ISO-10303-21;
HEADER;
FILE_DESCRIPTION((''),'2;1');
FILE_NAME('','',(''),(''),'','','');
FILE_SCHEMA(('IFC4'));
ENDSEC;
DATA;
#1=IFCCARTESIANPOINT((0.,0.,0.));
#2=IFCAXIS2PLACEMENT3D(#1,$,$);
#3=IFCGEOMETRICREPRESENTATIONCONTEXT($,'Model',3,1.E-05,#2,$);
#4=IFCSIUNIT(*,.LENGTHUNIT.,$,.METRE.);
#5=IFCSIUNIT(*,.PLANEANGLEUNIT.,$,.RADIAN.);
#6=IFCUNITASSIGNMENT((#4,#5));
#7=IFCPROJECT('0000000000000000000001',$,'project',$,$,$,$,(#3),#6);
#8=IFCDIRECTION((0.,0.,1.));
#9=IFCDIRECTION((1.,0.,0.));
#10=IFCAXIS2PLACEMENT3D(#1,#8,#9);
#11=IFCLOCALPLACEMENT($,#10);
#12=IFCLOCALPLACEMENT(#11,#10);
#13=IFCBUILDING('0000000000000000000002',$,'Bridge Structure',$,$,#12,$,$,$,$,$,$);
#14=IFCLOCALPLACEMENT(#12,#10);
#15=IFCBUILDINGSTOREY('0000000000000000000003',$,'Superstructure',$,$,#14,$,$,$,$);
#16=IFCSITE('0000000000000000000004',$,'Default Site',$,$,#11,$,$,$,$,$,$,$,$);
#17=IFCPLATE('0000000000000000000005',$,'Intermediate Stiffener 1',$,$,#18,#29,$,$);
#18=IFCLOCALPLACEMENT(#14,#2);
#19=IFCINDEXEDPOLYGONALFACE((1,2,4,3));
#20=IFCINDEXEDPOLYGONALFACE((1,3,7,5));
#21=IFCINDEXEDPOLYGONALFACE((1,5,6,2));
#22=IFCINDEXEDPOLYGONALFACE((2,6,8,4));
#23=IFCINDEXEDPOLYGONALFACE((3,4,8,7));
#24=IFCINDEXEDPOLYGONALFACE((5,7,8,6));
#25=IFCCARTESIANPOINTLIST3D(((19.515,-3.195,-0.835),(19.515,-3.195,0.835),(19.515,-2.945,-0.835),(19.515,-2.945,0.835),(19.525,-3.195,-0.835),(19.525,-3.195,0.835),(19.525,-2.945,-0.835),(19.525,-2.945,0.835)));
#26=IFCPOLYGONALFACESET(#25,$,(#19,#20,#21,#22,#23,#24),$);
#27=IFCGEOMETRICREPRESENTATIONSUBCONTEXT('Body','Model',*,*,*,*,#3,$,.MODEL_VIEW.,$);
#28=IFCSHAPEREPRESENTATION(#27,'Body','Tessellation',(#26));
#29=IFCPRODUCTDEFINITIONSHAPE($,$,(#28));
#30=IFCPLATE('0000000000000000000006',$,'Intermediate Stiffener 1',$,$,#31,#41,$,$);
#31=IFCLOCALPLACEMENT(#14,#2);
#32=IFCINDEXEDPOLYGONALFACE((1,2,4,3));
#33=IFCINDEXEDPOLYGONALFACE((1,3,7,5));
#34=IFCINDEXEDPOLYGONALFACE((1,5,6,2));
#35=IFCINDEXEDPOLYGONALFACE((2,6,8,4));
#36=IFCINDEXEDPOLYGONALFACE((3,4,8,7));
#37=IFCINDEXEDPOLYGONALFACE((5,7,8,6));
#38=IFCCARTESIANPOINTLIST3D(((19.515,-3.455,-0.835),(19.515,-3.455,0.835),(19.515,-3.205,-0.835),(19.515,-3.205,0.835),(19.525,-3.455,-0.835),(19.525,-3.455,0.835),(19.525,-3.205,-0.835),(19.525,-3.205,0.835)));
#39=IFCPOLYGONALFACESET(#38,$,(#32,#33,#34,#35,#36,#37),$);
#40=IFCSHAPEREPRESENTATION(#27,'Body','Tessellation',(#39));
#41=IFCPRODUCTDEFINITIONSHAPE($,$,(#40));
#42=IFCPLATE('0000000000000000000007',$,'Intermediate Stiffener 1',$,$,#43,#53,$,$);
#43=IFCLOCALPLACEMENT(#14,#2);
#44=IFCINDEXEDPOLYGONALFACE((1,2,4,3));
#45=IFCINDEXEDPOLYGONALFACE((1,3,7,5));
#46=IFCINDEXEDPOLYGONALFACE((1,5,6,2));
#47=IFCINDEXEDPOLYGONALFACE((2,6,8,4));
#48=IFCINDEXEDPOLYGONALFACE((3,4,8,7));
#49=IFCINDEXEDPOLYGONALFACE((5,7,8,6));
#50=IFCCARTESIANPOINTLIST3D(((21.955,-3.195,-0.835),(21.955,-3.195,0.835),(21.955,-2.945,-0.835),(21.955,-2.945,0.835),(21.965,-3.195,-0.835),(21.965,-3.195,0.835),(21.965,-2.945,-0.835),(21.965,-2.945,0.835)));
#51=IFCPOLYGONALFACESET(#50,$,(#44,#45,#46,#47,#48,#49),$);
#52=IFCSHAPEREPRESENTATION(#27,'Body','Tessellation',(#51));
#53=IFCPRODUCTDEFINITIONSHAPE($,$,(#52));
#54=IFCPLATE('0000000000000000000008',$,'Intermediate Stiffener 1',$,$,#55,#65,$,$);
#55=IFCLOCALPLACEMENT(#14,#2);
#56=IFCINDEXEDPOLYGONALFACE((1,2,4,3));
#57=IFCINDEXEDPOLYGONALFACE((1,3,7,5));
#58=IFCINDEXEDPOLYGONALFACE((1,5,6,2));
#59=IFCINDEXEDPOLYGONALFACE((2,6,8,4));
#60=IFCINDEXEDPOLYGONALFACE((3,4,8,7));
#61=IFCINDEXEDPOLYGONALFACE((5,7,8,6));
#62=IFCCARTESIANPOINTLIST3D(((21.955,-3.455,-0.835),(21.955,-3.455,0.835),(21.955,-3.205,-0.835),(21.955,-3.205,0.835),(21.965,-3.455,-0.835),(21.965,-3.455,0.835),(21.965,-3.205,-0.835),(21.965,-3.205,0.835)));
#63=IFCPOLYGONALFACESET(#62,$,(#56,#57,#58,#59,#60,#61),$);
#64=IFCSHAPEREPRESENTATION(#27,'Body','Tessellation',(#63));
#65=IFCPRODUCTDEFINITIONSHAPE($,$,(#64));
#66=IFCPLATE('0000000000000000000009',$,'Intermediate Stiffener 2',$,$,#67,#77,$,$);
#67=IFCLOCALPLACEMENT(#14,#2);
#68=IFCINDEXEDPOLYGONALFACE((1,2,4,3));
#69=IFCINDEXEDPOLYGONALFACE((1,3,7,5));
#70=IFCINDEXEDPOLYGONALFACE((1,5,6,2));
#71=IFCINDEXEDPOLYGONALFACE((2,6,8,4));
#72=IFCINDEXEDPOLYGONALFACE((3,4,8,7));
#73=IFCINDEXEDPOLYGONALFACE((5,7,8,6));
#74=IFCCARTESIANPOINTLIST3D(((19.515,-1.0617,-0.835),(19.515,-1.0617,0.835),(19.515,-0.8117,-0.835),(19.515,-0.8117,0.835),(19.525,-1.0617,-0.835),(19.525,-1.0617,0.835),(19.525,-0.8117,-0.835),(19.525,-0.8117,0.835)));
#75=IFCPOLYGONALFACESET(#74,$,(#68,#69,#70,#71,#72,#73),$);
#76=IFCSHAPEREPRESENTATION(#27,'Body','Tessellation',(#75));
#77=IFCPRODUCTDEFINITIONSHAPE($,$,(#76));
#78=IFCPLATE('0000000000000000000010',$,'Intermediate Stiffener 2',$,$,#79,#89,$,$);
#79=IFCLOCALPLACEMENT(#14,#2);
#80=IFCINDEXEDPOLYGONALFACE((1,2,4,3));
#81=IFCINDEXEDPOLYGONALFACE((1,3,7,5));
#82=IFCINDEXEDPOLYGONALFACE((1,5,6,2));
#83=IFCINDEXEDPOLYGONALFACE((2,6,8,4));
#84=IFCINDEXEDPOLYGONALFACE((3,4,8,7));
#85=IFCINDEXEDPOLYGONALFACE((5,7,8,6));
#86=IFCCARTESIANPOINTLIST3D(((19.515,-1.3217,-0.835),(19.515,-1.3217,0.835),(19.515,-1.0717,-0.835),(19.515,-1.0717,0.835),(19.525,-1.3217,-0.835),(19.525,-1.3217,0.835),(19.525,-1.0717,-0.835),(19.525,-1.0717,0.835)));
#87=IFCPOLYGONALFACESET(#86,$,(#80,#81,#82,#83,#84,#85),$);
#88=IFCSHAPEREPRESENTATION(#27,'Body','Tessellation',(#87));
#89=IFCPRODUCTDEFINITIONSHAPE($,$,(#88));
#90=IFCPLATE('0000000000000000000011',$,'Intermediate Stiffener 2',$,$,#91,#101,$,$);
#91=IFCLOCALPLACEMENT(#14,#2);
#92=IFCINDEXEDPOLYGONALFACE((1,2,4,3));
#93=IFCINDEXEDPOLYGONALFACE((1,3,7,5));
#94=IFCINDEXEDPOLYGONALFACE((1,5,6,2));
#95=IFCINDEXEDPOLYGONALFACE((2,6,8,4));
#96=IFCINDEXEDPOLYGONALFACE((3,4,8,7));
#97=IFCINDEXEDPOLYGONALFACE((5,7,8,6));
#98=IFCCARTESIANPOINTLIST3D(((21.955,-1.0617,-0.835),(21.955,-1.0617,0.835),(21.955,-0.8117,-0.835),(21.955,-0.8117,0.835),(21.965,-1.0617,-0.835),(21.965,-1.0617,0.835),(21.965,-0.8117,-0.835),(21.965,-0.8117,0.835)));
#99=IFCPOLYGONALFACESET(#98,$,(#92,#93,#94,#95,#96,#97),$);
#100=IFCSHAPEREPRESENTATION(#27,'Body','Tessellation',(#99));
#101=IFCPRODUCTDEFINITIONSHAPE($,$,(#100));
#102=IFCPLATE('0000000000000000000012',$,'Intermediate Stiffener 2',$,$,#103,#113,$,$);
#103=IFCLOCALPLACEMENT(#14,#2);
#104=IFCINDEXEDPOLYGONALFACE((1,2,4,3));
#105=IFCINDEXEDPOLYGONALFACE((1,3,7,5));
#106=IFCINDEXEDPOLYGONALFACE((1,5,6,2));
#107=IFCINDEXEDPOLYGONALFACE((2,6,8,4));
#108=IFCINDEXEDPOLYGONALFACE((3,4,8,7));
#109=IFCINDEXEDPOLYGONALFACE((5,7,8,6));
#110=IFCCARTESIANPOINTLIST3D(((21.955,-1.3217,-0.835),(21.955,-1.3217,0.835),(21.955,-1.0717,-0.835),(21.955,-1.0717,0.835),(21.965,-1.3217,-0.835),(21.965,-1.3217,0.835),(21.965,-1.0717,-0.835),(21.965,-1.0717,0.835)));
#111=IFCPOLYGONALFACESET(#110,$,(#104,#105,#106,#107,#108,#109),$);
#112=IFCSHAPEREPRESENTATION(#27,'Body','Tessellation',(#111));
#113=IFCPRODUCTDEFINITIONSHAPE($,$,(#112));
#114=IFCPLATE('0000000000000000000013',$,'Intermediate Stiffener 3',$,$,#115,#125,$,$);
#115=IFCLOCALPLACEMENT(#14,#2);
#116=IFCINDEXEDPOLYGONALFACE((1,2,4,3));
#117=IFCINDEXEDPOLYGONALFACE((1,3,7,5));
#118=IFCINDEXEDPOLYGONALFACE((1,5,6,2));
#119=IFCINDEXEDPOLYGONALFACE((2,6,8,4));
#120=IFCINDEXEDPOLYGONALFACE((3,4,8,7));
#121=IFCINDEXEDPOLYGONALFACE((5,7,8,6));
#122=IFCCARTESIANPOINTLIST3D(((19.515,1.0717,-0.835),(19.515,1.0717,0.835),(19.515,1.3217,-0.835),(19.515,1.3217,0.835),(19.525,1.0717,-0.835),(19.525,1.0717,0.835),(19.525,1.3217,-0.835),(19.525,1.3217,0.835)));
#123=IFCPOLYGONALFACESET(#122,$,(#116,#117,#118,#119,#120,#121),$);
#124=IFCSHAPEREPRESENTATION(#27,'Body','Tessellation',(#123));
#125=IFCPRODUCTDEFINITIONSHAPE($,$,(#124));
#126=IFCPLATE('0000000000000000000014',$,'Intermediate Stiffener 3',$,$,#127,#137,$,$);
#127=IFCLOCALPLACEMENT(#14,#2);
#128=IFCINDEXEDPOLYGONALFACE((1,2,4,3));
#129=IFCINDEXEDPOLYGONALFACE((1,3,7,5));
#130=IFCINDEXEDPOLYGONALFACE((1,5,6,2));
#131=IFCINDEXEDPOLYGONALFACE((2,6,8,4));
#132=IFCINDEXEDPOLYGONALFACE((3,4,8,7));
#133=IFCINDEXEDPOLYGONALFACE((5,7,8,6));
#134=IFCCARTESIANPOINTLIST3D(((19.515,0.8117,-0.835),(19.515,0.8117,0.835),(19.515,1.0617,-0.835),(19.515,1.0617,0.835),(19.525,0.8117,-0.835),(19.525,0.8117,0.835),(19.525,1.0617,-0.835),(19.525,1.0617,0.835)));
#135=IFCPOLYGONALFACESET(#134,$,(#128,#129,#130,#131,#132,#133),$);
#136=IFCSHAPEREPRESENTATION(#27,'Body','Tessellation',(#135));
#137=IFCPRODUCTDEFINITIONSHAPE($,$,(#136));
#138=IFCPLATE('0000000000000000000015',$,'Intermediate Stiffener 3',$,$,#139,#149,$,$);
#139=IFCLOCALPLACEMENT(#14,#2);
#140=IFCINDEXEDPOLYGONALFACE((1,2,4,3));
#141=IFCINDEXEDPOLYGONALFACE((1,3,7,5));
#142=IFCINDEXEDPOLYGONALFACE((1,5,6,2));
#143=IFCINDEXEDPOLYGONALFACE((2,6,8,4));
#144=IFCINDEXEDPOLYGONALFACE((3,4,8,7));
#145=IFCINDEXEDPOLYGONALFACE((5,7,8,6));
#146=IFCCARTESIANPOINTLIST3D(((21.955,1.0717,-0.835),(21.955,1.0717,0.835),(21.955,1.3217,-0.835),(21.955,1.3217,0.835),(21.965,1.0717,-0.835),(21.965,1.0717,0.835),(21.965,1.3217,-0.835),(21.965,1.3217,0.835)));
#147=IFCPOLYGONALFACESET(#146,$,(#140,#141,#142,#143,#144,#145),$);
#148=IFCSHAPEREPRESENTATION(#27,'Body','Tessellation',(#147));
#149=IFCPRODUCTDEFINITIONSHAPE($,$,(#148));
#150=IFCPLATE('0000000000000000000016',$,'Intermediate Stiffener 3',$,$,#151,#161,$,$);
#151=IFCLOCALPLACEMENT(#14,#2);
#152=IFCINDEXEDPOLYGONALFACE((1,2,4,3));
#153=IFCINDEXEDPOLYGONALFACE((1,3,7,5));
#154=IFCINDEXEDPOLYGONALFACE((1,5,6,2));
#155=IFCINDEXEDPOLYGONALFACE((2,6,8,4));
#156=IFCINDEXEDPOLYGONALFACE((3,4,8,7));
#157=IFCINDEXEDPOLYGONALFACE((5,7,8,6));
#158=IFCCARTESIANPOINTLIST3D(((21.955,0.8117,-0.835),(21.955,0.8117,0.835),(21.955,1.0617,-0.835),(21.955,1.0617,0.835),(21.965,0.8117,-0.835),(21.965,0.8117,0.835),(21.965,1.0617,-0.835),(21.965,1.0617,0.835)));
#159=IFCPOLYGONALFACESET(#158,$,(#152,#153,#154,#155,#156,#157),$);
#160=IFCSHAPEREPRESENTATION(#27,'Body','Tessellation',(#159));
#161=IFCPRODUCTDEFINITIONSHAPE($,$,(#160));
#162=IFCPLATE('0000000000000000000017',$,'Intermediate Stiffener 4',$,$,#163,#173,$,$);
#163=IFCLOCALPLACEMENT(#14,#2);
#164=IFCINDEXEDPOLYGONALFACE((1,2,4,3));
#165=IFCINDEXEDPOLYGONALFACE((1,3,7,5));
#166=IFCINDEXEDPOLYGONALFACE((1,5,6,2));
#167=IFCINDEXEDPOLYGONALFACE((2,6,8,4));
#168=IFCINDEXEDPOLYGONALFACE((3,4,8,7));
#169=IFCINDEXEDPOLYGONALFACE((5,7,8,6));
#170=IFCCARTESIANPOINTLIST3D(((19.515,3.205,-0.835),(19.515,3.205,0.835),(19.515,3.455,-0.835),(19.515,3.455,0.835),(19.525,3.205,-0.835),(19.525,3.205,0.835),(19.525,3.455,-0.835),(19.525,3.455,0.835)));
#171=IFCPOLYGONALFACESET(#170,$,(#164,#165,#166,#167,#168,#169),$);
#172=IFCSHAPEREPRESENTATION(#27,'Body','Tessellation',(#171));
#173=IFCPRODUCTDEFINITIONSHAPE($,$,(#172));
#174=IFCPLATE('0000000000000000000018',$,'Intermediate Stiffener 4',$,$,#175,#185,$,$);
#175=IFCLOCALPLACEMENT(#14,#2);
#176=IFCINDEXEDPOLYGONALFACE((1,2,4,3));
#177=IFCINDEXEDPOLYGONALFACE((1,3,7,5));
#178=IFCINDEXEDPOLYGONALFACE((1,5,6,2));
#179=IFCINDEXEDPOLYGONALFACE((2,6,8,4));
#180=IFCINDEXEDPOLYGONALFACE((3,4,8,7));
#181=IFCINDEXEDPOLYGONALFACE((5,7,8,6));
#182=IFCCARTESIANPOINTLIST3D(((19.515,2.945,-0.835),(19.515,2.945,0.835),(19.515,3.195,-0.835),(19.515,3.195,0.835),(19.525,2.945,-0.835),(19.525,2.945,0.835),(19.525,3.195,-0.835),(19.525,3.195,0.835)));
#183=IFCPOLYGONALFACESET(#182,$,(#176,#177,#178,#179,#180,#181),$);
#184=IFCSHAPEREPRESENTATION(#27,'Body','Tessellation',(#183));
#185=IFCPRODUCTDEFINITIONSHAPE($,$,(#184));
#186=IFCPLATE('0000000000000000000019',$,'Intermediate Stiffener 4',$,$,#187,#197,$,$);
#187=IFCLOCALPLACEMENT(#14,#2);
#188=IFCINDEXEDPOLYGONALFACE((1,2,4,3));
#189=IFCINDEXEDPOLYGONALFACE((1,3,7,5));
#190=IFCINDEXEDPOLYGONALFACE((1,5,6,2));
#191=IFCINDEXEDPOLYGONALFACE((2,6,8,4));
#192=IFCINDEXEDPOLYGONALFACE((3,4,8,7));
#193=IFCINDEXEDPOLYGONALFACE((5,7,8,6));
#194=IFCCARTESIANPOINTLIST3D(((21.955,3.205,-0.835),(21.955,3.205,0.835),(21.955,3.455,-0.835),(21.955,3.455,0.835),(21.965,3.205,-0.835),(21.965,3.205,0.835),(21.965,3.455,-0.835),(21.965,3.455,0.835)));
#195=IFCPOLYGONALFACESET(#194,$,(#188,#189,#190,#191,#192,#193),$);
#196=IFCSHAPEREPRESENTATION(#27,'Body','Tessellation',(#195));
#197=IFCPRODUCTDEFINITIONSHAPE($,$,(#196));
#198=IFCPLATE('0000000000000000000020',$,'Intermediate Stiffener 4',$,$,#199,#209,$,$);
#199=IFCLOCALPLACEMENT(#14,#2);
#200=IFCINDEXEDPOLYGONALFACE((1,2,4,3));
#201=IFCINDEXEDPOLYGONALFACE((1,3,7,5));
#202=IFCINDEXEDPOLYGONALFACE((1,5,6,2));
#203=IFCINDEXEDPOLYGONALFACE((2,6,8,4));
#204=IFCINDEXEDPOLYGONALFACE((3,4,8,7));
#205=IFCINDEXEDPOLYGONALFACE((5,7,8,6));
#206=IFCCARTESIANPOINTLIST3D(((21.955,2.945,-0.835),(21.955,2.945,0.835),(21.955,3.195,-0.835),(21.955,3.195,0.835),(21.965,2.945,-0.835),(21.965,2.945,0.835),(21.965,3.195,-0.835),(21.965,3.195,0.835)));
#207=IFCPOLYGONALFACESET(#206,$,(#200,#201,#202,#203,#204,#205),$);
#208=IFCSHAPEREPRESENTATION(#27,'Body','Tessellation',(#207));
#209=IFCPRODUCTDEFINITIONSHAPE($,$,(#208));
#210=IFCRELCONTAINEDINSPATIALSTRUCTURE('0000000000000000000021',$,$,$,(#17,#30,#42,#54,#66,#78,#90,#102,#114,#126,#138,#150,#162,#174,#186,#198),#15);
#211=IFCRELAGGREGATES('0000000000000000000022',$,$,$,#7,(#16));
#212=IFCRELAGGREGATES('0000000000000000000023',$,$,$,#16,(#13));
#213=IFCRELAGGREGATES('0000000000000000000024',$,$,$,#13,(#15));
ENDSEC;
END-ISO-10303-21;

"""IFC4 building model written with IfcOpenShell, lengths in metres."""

from ifc_helpers import new_model, si_unit, frame, origin, origin_with_axes, origin_2d_with_axis, place, context, subcontext, project, spatial, rectangle, extrude, element, save


model = new_model("IFC4")

# Units and contexts
model_context = context("Model", 3, precision=1e-05, world=origin())
body_context = subcontext(model_context, "Body", "Model", "MODEL_VIEW")
ifc_project = project(units=[si_unit("LENGTHUNIT", "METRE"), si_unit("PLANEANGLEUNIT", "RADIAN")], contexts=[model_context])

# Site, building, storey
site_placement = place(None, origin_with_axes())
site = spatial("IfcSite", under=ifc_project, at=site_placement, Name="Default Site")
building_placement = place(site_placement, origin_with_axes())
building = spatial("IfcBuilding", under=site, at=building_placement, Name="Bridge Structure")
storey_placement = place(building_placement, origin_with_axes())
storey = spatial("IfcBuildingStorey", under=building, at=storey_placement, Name="Superstructure")

# Plates
for number, where, z_axis, x_axis, name in (
    (1, (19.52, -3.07, -0.835), (0.0, 0.0, 1.0), (1.0, 0.0, 0.0), "Intermediate Stiffener 1"),
    (2, (19.52, -3.33, -0.835), (0.0, 0.0, 1.0), (1.0, 0.0, 0.0), "Intermediate Stiffener 1"),
    (3, (21.96, -3.07, -0.835), (0.0, 0.0, 1.0), (1.0, 0.0, 0.0), "Intermediate Stiffener 1"),
    (4, (21.96, -3.33, -0.835), (0.0, 0.0, 1.0), (1.0, 0.0, 0.0), "Intermediate Stiffener 1"),
    (5, (19.52, -0.9367, -0.835), (0.0, 0.0, 1.0), (1.0, 0.0, 0.0), "Intermediate Stiffener 2"),
    (6, (19.52, -1.1967, -0.835), (0.0, 0.0, 1.0), (1.0, 0.0, 0.0), "Intermediate Stiffener 2"),
    (7, (21.96, -0.9367, -0.835), (0.0, 0.0, 1.0), (1.0, 0.0, 0.0), "Intermediate Stiffener 2"),
    (8, (21.96, -1.1967, -0.835), (0.0, 0.0, 1.0), (1.0, 0.0, 0.0), "Intermediate Stiffener 2"),
    (9, (19.52, 1.1967, -0.835), (0.0, 0.0, 1.0), (1.0, 0.0, 0.0), "Intermediate Stiffener 3"),
    (10, (19.52, 0.9367, -0.835), (0.0, 0.0, 1.0), (1.0, 0.0, 0.0), "Intermediate Stiffener 3"),
    (11, (21.96, 1.1967, -0.835), (0.0, 0.0, 1.0), (1.0, 0.0, 0.0), "Intermediate Stiffener 3"),
    (12, (21.96, 0.9367, -0.835), (0.0, 0.0, 1.0), (1.0, 0.0, 0.0), "Intermediate Stiffener 3"),
    (13, (19.52, 3.33, -0.835), (0.0, 0.0, 1.0), (1.0, 0.0, 0.0), "Intermediate Stiffener 4"),
    (14, (19.52, 3.07, -0.835), (0.0, 0.0, 1.0), (1.0, 0.0, 0.0), "Intermediate Stiffener 4"),
    (15, (21.96, 3.33, -0.835), (0.0, 0.0, 1.0), (1.0, 0.0, 0.0), "Intermediate Stiffener 4"),
    (16, (21.96, 3.07, -0.835), (0.0, 0.0, 1.0), (1.0, 0.0, 0.0), "Intermediate Stiffener 4"),
):
    element("IfcPlate", number, at=place(storey_placement, frame(where, z_axis=z_axis, x_axis=x_axis)), inside=storey, Name=name, context=body_context, shape_type="SweptSolid", body=[
        extrude(rectangle(XDim=0.01, YDim=0.25, at=origin_2d_with_axis()), origin_with_axes(), (0.0, 0.0, 1.0), 1.67),
    ])

save(model, "model.ifc")
